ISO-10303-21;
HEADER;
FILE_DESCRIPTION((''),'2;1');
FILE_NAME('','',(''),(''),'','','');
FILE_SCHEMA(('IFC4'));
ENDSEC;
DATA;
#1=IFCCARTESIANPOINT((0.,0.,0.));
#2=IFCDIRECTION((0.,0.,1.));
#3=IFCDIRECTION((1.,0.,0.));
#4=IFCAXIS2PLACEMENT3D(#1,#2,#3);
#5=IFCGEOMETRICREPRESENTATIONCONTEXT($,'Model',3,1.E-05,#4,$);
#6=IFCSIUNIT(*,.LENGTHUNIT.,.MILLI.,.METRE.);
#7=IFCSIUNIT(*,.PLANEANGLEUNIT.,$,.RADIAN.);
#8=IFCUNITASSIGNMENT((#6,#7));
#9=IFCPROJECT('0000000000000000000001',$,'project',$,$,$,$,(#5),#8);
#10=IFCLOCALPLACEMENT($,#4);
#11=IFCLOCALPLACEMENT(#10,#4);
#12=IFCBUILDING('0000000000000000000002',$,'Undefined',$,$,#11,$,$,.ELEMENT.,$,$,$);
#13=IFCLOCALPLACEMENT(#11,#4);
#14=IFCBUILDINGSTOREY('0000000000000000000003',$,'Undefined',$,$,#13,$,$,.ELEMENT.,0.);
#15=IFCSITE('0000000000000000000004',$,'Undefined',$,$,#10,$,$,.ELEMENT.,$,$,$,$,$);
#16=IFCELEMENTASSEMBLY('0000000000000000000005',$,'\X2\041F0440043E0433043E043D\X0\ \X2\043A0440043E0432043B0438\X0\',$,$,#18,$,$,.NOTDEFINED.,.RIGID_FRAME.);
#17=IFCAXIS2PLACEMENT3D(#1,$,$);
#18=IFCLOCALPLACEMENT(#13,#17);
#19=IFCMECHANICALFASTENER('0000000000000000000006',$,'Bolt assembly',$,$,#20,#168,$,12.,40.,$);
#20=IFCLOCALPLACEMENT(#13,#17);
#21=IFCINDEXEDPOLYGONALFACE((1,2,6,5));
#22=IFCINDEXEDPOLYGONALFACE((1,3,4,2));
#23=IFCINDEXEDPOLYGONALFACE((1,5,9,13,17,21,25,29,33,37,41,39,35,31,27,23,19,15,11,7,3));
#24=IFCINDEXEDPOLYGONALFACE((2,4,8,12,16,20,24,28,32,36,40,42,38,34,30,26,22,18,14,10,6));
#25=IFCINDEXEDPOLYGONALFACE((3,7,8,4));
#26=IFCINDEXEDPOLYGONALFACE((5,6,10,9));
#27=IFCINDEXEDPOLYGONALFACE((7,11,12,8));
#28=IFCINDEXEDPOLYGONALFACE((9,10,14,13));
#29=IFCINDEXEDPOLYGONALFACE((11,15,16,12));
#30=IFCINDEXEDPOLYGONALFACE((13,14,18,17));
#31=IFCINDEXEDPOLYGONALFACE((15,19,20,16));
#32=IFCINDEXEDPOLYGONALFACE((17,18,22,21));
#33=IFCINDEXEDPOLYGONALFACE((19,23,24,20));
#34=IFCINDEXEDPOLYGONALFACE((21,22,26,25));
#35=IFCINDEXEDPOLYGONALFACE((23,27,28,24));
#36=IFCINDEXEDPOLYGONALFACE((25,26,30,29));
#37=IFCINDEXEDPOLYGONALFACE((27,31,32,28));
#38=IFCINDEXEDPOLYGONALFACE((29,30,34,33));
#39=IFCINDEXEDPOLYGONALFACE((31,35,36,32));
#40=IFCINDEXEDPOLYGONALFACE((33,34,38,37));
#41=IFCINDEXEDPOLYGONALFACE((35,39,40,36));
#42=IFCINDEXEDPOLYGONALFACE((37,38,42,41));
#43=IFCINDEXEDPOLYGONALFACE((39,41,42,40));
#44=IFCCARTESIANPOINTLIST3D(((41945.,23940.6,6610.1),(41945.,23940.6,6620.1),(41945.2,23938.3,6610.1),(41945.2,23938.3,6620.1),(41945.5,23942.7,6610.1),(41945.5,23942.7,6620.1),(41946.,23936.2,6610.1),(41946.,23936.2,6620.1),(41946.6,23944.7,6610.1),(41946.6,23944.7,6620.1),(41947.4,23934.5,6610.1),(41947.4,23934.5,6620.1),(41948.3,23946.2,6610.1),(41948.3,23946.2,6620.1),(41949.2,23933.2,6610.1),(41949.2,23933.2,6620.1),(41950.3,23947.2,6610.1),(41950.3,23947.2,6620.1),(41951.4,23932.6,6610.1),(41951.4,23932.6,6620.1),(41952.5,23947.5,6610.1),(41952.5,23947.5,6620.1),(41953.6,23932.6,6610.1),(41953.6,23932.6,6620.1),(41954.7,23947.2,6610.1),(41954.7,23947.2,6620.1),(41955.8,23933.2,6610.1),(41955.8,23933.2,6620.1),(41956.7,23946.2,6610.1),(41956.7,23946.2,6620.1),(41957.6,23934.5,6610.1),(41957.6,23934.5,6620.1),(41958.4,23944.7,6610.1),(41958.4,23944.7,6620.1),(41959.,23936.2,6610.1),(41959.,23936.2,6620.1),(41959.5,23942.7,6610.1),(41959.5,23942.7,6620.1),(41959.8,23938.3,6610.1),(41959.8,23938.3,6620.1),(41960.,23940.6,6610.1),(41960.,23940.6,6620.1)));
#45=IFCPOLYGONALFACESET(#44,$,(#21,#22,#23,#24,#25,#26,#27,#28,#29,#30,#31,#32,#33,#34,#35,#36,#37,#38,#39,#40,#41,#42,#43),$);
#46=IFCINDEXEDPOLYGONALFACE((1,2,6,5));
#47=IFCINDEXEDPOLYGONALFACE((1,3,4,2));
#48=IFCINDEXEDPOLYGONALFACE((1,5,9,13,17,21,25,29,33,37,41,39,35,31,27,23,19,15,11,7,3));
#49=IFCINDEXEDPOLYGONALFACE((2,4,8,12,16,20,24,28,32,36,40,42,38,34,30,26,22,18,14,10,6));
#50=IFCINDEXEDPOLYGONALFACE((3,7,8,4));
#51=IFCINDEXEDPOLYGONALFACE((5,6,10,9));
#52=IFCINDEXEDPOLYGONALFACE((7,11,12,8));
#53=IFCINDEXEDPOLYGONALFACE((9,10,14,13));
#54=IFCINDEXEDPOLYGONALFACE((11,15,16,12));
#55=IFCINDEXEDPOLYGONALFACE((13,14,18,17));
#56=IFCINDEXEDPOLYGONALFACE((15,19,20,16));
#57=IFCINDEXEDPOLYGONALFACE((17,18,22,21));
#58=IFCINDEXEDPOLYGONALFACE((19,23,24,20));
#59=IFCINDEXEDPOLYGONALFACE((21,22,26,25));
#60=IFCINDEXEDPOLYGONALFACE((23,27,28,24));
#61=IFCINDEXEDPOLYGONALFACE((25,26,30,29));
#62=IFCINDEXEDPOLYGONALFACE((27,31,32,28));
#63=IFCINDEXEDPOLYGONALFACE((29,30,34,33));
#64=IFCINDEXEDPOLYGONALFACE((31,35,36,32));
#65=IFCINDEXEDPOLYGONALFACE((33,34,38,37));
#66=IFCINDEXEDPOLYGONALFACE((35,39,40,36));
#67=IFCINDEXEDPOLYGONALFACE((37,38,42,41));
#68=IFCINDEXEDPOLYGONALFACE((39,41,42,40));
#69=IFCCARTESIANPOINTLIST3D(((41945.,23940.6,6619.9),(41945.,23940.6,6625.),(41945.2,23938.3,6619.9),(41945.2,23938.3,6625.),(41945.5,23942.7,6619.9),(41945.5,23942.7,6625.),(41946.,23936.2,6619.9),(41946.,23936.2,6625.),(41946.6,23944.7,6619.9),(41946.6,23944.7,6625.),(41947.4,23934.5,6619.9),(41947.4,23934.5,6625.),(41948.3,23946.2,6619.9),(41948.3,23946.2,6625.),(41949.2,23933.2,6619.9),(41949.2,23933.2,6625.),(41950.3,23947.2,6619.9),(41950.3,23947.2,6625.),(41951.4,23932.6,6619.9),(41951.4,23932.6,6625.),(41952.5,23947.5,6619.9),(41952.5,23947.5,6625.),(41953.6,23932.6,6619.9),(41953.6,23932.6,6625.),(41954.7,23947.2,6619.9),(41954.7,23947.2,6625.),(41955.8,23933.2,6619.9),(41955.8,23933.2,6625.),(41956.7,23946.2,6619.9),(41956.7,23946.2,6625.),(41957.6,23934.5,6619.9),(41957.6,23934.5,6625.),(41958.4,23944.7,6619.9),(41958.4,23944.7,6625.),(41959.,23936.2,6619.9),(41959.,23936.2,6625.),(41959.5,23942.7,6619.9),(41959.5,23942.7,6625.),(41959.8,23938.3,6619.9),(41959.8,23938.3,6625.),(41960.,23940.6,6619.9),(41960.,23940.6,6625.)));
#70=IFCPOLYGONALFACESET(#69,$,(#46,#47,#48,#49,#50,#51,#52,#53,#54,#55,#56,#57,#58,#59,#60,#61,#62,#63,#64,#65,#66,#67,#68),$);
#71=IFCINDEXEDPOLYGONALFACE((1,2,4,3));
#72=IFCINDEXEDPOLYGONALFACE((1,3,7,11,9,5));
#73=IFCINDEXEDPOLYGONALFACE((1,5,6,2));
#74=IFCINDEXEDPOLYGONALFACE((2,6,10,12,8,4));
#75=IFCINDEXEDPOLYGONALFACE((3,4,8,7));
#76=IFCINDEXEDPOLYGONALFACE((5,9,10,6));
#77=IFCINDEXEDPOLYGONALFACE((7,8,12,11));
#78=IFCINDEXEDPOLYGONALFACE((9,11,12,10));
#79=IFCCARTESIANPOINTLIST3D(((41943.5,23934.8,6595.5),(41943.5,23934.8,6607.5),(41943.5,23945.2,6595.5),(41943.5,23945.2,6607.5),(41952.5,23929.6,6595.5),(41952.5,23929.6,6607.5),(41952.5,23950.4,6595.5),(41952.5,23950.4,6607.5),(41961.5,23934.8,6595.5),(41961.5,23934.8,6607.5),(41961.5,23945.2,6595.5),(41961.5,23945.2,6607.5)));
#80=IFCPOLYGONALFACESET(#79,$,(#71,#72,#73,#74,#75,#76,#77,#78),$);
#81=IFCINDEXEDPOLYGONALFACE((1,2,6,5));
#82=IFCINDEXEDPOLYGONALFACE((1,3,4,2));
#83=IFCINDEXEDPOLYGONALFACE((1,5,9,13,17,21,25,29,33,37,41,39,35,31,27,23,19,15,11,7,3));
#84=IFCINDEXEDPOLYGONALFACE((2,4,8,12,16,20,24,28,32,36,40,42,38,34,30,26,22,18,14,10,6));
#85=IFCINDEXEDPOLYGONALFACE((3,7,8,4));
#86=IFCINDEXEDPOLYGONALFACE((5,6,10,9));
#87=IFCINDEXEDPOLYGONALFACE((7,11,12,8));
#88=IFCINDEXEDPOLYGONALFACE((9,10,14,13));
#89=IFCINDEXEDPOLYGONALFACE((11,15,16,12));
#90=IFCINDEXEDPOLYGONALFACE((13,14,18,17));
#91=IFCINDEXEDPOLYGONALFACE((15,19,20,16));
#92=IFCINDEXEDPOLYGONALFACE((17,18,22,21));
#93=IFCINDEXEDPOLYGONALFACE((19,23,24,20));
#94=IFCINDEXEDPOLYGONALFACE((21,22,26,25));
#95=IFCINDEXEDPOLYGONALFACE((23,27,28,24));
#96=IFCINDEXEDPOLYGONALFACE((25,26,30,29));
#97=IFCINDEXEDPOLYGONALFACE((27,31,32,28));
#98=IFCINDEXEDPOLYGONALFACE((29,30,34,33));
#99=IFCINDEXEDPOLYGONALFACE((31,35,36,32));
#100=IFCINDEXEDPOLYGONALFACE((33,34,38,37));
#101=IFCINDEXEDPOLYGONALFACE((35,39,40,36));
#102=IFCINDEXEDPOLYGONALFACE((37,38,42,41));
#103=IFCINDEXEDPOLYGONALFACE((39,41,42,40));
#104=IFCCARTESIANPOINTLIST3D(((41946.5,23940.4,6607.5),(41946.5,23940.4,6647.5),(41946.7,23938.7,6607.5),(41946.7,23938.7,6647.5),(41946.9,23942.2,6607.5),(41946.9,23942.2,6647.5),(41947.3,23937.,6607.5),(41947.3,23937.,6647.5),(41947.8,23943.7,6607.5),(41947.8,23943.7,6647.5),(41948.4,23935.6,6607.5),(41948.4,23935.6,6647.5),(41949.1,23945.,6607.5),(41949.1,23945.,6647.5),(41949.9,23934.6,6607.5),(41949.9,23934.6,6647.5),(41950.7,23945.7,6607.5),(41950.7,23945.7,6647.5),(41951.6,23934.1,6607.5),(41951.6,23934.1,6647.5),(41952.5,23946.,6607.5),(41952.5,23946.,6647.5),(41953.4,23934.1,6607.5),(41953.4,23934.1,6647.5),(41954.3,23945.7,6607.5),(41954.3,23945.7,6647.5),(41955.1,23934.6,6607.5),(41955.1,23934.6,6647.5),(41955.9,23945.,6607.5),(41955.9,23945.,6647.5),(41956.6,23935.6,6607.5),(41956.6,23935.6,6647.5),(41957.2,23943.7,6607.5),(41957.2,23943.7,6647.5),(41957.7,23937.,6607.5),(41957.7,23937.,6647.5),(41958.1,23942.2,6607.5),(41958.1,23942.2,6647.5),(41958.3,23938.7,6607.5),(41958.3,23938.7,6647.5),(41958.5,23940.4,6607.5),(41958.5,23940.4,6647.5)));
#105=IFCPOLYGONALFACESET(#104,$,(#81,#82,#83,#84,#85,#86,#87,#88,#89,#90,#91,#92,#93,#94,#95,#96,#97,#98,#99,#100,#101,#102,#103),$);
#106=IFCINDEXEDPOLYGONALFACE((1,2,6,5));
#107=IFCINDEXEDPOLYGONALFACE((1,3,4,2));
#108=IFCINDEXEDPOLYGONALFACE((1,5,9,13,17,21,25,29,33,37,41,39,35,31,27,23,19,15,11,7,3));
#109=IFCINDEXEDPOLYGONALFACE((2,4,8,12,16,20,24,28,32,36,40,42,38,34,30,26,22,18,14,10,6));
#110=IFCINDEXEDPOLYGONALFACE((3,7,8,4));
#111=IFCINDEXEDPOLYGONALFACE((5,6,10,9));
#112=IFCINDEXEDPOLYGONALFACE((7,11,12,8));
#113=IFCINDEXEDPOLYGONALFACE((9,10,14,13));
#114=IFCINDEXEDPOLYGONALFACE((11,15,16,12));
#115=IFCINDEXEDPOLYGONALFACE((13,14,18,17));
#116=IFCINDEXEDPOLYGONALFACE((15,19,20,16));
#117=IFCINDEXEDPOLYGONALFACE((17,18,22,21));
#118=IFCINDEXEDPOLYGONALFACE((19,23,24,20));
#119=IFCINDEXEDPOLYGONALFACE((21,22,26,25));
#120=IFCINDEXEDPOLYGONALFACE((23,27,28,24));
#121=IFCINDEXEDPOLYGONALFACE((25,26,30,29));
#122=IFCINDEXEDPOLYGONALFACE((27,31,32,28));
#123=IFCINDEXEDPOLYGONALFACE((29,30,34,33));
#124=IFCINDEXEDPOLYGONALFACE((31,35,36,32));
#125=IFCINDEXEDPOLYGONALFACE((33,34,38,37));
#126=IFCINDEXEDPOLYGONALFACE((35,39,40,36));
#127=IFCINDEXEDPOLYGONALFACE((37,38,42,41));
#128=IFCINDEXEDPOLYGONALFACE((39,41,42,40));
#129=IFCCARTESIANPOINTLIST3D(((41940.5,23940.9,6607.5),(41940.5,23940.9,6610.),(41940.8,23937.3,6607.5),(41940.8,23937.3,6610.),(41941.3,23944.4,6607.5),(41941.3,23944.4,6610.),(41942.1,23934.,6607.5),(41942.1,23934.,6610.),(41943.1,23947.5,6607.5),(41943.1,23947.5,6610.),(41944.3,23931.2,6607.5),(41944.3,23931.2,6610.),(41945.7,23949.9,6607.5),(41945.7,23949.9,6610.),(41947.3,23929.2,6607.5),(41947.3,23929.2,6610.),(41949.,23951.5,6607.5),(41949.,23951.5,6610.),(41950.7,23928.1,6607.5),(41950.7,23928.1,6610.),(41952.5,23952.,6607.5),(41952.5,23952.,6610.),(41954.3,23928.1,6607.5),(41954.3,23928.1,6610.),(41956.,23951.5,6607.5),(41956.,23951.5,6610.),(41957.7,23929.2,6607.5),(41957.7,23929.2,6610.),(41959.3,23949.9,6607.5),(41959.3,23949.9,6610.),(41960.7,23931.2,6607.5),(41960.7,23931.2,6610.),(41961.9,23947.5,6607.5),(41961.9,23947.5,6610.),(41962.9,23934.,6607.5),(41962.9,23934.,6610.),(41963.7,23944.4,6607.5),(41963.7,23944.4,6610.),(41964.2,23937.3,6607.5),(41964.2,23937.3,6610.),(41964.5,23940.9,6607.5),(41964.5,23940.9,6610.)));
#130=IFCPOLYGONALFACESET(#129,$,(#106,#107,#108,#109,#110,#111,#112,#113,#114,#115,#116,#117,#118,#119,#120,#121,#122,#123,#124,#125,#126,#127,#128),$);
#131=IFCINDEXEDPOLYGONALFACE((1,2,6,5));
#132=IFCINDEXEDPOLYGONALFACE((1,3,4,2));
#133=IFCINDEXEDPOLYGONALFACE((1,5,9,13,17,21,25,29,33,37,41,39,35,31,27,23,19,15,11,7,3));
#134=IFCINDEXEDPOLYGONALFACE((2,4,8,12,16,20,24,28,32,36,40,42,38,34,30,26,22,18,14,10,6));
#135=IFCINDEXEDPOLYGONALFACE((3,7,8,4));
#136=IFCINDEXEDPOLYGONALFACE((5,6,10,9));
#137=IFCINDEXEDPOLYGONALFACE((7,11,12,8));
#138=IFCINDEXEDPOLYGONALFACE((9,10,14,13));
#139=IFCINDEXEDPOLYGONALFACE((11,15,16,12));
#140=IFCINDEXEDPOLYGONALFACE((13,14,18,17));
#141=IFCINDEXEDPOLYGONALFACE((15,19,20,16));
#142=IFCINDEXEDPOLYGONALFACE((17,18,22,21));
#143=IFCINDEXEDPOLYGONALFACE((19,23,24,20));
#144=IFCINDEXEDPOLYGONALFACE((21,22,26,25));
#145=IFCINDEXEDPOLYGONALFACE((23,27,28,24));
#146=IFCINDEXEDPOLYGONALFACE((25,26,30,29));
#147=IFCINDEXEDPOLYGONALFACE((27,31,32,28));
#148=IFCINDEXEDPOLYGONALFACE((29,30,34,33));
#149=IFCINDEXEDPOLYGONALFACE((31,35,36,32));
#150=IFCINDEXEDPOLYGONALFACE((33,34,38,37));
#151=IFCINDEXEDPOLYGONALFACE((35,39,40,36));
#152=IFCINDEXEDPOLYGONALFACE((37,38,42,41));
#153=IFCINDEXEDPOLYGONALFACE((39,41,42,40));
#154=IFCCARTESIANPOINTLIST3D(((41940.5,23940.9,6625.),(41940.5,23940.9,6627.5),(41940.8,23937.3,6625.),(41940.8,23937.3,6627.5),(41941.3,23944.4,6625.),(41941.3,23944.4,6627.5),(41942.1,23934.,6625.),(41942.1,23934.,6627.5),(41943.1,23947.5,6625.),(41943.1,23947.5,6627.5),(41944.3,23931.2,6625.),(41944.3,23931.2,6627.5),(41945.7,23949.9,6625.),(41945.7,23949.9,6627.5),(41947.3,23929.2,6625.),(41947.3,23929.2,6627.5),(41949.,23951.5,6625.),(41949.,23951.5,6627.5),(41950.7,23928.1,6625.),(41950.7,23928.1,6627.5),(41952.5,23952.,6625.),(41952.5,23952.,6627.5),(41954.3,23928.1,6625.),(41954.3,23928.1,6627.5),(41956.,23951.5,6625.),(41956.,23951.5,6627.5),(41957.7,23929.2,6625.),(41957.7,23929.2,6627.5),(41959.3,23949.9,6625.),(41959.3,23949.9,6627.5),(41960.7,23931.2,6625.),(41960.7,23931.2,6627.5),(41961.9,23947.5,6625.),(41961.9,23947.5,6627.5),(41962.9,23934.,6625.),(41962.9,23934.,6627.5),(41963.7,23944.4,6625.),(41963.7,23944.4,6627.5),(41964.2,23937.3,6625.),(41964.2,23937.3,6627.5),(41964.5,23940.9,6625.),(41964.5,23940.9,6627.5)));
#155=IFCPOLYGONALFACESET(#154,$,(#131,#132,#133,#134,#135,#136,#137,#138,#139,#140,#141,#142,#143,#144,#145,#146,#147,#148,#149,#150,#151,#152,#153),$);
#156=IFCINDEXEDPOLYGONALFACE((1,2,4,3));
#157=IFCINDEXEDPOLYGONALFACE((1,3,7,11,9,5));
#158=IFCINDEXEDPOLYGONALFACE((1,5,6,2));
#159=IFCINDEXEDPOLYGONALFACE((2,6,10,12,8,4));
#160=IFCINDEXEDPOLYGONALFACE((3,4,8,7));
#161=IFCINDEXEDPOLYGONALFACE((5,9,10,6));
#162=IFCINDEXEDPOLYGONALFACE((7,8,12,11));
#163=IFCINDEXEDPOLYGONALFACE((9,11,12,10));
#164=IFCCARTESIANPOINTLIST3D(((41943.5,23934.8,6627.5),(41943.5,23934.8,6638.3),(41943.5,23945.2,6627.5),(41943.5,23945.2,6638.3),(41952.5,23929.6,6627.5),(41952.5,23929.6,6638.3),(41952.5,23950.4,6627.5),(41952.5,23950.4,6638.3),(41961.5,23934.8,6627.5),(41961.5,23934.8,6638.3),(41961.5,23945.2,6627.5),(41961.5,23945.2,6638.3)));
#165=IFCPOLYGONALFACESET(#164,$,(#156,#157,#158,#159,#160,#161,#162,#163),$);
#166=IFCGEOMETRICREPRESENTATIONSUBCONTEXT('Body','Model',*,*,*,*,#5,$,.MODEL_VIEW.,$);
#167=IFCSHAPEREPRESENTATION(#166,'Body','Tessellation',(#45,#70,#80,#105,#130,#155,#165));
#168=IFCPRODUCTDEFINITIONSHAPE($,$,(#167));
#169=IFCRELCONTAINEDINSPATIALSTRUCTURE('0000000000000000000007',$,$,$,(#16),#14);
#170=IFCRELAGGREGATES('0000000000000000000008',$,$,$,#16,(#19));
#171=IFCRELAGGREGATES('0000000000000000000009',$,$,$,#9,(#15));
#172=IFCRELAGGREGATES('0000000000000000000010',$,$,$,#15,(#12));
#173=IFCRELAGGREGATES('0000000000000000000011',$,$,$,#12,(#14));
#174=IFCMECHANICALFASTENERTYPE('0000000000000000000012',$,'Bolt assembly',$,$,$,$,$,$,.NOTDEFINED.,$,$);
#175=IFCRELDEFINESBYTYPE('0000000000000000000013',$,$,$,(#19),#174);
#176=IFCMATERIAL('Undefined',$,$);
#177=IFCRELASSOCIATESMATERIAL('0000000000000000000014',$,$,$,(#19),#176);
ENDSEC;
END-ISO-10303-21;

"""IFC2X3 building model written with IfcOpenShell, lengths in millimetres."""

from ifc_helpers import new_model, si_unit, frame, origin_with_axes, origin_2d_with_axis, place, context, subcontext, project, spatial, polyline, circle, outline, extrude, source, transform, mapped, material, type_object, element, aggregate, save


model = new_model("IFC2X3")

# Units and contexts
model_context = context("Model", 3, precision=1e-05, world=origin_with_axes())
body_context = subcontext(model_context, "Body", "Model", "MODEL_VIEW")
ifc_project = project(units=[si_unit("LENGTHUNIT", "METRE", prefix="MILLI"), si_unit("PLANEANGLEUNIT", "RADIAN")], contexts=[model_context])

# Site, building, storey
site_placement = place(None, origin_with_axes())
site = spatial("IfcSite", under=ifc_project, at=site_placement, Name="Undefined", CompositionType="ELEMENT")
building_placement = place(site_placement, origin_with_axes())
building = spatial("IfcBuilding", under=site, at=building_placement, Name="Undefined", CompositionType="ELEMENT")
storey_placement = place(building_placement, origin_with_axes())
storey = spatial("IfcBuildingStorey", under=building, at=storey_placement, Name="Undefined", CompositionType="ELEMENT", Elevation=0.0)

# Element assembly
assembly_1_placement = place(storey_placement, origin_with_axes())
assembly_1 = element("IfcElementAssembly", 1, at=assembly_1_placement, inside=storey, Name="Прогон кровли", AssemblyPlace="NOTDEFINED", PredefinedType="RIGID_FRAME")

# Mechanical fastener
ifc_material_1 = material(Name="Undefined")
mechanical_fastener_type = type_object("IfcMechanicalFastenerType", Name="Bolt assembly")
shared_shape_1 = source(origin_with_axes(), body_context, "Body", "SweptSolid", [
    extrude(circle(Radius=7.5, at=origin_2d_with_axis()), frame((0.0, -9.9, 0.0), z_axis=(0.0, 1.0, 0.0), x_axis=(1.0, 0.0, 0.0)), (0.0, 0.0, 1.0), 10.0),
    extrude(circle(Radius=7.5, at=origin_2d_with_axis()), frame((0.0, -0.1, 0.0), z_axis=(0.0, 1.0, 0.0), x_axis=(1.0, 0.0, 0.0)), (0.0, 0.0, 1.0), 5.1),
    extrude(outline(polyline([(10.4, 0.0), (5.2, 9.0), (-5.2, 9.0), (-10.4, 0.0), (-5.2, -9.0), (5.2, -9.0), (10.4, 0.0)])), frame((0.0, -24.5, 0.0), z_axis=(0.0, 1.0, 0.0), x_axis=(1.0, 0.0, 0.0)), (0.0, 0.0, 1.0), 12.0),
    extrude(circle(Radius=6.0, at=origin_2d_with_axis()), frame((0.0, -12.5, 0.0), z_axis=(0.0, 1.0, 0.0), x_axis=(1.0, 0.0, 0.0)), (0.0, 0.0, 1.0), 40.0),
    extrude(circle(Radius=12.0, at=origin_2d_with_axis()), frame((0.0, -12.5, 0.0), z_axis=(0.0, 1.0, 0.0), x_axis=(1.0, 0.0, 0.0)), (0.0, 0.0, 1.0), 2.5),
    extrude(circle(Radius=12.0, at=origin_2d_with_axis()), frame((0.0, 5.0, 0.0), z_axis=(0.0, 1.0, 0.0), x_axis=(1.0, 0.0, 0.0)), (0.0, 0.0, 1.0), 2.5),
    extrude(outline(polyline([(10.4, 0.0), (5.2, 9.0), (-5.2, 9.0), (-10.4, 0.0), (-5.2, -9.0), (5.2, -9.0), (10.4, 0.0)])), frame((0.0, 7.5, 0.0), z_axis=(0.0, 1.0, 0.0), x_axis=(1.0, 0.0, 0.0)), (0.0, 0.0, 1.0), 10.8),
])
mechanical_fastener_1_placement = place(assembly_1_placement, frame((41952.5, 23940.0, 6620.0), z_axis=(1.0, 0.0, 0.0), x_axis=(0.0, 1.0, 0.0)))
mechanical_fastener_1 = element("IfcMechanicalFastener", 2, at=mechanical_fastener_1_placement, type_object=mechanical_fastener_type, material=ifc_material_1, Name="Bolt assembly", NominalDiameter=12.0, NominalLength=40.0, context=body_context, shape_type="MappedRepresentation", body=[
    mapped(shared_shape_1, transform((0.0, 0.0, 0.0))),
])
aggregate(assembly_1, [mechanical_fastener_1])

save(model, "model.ifc")
